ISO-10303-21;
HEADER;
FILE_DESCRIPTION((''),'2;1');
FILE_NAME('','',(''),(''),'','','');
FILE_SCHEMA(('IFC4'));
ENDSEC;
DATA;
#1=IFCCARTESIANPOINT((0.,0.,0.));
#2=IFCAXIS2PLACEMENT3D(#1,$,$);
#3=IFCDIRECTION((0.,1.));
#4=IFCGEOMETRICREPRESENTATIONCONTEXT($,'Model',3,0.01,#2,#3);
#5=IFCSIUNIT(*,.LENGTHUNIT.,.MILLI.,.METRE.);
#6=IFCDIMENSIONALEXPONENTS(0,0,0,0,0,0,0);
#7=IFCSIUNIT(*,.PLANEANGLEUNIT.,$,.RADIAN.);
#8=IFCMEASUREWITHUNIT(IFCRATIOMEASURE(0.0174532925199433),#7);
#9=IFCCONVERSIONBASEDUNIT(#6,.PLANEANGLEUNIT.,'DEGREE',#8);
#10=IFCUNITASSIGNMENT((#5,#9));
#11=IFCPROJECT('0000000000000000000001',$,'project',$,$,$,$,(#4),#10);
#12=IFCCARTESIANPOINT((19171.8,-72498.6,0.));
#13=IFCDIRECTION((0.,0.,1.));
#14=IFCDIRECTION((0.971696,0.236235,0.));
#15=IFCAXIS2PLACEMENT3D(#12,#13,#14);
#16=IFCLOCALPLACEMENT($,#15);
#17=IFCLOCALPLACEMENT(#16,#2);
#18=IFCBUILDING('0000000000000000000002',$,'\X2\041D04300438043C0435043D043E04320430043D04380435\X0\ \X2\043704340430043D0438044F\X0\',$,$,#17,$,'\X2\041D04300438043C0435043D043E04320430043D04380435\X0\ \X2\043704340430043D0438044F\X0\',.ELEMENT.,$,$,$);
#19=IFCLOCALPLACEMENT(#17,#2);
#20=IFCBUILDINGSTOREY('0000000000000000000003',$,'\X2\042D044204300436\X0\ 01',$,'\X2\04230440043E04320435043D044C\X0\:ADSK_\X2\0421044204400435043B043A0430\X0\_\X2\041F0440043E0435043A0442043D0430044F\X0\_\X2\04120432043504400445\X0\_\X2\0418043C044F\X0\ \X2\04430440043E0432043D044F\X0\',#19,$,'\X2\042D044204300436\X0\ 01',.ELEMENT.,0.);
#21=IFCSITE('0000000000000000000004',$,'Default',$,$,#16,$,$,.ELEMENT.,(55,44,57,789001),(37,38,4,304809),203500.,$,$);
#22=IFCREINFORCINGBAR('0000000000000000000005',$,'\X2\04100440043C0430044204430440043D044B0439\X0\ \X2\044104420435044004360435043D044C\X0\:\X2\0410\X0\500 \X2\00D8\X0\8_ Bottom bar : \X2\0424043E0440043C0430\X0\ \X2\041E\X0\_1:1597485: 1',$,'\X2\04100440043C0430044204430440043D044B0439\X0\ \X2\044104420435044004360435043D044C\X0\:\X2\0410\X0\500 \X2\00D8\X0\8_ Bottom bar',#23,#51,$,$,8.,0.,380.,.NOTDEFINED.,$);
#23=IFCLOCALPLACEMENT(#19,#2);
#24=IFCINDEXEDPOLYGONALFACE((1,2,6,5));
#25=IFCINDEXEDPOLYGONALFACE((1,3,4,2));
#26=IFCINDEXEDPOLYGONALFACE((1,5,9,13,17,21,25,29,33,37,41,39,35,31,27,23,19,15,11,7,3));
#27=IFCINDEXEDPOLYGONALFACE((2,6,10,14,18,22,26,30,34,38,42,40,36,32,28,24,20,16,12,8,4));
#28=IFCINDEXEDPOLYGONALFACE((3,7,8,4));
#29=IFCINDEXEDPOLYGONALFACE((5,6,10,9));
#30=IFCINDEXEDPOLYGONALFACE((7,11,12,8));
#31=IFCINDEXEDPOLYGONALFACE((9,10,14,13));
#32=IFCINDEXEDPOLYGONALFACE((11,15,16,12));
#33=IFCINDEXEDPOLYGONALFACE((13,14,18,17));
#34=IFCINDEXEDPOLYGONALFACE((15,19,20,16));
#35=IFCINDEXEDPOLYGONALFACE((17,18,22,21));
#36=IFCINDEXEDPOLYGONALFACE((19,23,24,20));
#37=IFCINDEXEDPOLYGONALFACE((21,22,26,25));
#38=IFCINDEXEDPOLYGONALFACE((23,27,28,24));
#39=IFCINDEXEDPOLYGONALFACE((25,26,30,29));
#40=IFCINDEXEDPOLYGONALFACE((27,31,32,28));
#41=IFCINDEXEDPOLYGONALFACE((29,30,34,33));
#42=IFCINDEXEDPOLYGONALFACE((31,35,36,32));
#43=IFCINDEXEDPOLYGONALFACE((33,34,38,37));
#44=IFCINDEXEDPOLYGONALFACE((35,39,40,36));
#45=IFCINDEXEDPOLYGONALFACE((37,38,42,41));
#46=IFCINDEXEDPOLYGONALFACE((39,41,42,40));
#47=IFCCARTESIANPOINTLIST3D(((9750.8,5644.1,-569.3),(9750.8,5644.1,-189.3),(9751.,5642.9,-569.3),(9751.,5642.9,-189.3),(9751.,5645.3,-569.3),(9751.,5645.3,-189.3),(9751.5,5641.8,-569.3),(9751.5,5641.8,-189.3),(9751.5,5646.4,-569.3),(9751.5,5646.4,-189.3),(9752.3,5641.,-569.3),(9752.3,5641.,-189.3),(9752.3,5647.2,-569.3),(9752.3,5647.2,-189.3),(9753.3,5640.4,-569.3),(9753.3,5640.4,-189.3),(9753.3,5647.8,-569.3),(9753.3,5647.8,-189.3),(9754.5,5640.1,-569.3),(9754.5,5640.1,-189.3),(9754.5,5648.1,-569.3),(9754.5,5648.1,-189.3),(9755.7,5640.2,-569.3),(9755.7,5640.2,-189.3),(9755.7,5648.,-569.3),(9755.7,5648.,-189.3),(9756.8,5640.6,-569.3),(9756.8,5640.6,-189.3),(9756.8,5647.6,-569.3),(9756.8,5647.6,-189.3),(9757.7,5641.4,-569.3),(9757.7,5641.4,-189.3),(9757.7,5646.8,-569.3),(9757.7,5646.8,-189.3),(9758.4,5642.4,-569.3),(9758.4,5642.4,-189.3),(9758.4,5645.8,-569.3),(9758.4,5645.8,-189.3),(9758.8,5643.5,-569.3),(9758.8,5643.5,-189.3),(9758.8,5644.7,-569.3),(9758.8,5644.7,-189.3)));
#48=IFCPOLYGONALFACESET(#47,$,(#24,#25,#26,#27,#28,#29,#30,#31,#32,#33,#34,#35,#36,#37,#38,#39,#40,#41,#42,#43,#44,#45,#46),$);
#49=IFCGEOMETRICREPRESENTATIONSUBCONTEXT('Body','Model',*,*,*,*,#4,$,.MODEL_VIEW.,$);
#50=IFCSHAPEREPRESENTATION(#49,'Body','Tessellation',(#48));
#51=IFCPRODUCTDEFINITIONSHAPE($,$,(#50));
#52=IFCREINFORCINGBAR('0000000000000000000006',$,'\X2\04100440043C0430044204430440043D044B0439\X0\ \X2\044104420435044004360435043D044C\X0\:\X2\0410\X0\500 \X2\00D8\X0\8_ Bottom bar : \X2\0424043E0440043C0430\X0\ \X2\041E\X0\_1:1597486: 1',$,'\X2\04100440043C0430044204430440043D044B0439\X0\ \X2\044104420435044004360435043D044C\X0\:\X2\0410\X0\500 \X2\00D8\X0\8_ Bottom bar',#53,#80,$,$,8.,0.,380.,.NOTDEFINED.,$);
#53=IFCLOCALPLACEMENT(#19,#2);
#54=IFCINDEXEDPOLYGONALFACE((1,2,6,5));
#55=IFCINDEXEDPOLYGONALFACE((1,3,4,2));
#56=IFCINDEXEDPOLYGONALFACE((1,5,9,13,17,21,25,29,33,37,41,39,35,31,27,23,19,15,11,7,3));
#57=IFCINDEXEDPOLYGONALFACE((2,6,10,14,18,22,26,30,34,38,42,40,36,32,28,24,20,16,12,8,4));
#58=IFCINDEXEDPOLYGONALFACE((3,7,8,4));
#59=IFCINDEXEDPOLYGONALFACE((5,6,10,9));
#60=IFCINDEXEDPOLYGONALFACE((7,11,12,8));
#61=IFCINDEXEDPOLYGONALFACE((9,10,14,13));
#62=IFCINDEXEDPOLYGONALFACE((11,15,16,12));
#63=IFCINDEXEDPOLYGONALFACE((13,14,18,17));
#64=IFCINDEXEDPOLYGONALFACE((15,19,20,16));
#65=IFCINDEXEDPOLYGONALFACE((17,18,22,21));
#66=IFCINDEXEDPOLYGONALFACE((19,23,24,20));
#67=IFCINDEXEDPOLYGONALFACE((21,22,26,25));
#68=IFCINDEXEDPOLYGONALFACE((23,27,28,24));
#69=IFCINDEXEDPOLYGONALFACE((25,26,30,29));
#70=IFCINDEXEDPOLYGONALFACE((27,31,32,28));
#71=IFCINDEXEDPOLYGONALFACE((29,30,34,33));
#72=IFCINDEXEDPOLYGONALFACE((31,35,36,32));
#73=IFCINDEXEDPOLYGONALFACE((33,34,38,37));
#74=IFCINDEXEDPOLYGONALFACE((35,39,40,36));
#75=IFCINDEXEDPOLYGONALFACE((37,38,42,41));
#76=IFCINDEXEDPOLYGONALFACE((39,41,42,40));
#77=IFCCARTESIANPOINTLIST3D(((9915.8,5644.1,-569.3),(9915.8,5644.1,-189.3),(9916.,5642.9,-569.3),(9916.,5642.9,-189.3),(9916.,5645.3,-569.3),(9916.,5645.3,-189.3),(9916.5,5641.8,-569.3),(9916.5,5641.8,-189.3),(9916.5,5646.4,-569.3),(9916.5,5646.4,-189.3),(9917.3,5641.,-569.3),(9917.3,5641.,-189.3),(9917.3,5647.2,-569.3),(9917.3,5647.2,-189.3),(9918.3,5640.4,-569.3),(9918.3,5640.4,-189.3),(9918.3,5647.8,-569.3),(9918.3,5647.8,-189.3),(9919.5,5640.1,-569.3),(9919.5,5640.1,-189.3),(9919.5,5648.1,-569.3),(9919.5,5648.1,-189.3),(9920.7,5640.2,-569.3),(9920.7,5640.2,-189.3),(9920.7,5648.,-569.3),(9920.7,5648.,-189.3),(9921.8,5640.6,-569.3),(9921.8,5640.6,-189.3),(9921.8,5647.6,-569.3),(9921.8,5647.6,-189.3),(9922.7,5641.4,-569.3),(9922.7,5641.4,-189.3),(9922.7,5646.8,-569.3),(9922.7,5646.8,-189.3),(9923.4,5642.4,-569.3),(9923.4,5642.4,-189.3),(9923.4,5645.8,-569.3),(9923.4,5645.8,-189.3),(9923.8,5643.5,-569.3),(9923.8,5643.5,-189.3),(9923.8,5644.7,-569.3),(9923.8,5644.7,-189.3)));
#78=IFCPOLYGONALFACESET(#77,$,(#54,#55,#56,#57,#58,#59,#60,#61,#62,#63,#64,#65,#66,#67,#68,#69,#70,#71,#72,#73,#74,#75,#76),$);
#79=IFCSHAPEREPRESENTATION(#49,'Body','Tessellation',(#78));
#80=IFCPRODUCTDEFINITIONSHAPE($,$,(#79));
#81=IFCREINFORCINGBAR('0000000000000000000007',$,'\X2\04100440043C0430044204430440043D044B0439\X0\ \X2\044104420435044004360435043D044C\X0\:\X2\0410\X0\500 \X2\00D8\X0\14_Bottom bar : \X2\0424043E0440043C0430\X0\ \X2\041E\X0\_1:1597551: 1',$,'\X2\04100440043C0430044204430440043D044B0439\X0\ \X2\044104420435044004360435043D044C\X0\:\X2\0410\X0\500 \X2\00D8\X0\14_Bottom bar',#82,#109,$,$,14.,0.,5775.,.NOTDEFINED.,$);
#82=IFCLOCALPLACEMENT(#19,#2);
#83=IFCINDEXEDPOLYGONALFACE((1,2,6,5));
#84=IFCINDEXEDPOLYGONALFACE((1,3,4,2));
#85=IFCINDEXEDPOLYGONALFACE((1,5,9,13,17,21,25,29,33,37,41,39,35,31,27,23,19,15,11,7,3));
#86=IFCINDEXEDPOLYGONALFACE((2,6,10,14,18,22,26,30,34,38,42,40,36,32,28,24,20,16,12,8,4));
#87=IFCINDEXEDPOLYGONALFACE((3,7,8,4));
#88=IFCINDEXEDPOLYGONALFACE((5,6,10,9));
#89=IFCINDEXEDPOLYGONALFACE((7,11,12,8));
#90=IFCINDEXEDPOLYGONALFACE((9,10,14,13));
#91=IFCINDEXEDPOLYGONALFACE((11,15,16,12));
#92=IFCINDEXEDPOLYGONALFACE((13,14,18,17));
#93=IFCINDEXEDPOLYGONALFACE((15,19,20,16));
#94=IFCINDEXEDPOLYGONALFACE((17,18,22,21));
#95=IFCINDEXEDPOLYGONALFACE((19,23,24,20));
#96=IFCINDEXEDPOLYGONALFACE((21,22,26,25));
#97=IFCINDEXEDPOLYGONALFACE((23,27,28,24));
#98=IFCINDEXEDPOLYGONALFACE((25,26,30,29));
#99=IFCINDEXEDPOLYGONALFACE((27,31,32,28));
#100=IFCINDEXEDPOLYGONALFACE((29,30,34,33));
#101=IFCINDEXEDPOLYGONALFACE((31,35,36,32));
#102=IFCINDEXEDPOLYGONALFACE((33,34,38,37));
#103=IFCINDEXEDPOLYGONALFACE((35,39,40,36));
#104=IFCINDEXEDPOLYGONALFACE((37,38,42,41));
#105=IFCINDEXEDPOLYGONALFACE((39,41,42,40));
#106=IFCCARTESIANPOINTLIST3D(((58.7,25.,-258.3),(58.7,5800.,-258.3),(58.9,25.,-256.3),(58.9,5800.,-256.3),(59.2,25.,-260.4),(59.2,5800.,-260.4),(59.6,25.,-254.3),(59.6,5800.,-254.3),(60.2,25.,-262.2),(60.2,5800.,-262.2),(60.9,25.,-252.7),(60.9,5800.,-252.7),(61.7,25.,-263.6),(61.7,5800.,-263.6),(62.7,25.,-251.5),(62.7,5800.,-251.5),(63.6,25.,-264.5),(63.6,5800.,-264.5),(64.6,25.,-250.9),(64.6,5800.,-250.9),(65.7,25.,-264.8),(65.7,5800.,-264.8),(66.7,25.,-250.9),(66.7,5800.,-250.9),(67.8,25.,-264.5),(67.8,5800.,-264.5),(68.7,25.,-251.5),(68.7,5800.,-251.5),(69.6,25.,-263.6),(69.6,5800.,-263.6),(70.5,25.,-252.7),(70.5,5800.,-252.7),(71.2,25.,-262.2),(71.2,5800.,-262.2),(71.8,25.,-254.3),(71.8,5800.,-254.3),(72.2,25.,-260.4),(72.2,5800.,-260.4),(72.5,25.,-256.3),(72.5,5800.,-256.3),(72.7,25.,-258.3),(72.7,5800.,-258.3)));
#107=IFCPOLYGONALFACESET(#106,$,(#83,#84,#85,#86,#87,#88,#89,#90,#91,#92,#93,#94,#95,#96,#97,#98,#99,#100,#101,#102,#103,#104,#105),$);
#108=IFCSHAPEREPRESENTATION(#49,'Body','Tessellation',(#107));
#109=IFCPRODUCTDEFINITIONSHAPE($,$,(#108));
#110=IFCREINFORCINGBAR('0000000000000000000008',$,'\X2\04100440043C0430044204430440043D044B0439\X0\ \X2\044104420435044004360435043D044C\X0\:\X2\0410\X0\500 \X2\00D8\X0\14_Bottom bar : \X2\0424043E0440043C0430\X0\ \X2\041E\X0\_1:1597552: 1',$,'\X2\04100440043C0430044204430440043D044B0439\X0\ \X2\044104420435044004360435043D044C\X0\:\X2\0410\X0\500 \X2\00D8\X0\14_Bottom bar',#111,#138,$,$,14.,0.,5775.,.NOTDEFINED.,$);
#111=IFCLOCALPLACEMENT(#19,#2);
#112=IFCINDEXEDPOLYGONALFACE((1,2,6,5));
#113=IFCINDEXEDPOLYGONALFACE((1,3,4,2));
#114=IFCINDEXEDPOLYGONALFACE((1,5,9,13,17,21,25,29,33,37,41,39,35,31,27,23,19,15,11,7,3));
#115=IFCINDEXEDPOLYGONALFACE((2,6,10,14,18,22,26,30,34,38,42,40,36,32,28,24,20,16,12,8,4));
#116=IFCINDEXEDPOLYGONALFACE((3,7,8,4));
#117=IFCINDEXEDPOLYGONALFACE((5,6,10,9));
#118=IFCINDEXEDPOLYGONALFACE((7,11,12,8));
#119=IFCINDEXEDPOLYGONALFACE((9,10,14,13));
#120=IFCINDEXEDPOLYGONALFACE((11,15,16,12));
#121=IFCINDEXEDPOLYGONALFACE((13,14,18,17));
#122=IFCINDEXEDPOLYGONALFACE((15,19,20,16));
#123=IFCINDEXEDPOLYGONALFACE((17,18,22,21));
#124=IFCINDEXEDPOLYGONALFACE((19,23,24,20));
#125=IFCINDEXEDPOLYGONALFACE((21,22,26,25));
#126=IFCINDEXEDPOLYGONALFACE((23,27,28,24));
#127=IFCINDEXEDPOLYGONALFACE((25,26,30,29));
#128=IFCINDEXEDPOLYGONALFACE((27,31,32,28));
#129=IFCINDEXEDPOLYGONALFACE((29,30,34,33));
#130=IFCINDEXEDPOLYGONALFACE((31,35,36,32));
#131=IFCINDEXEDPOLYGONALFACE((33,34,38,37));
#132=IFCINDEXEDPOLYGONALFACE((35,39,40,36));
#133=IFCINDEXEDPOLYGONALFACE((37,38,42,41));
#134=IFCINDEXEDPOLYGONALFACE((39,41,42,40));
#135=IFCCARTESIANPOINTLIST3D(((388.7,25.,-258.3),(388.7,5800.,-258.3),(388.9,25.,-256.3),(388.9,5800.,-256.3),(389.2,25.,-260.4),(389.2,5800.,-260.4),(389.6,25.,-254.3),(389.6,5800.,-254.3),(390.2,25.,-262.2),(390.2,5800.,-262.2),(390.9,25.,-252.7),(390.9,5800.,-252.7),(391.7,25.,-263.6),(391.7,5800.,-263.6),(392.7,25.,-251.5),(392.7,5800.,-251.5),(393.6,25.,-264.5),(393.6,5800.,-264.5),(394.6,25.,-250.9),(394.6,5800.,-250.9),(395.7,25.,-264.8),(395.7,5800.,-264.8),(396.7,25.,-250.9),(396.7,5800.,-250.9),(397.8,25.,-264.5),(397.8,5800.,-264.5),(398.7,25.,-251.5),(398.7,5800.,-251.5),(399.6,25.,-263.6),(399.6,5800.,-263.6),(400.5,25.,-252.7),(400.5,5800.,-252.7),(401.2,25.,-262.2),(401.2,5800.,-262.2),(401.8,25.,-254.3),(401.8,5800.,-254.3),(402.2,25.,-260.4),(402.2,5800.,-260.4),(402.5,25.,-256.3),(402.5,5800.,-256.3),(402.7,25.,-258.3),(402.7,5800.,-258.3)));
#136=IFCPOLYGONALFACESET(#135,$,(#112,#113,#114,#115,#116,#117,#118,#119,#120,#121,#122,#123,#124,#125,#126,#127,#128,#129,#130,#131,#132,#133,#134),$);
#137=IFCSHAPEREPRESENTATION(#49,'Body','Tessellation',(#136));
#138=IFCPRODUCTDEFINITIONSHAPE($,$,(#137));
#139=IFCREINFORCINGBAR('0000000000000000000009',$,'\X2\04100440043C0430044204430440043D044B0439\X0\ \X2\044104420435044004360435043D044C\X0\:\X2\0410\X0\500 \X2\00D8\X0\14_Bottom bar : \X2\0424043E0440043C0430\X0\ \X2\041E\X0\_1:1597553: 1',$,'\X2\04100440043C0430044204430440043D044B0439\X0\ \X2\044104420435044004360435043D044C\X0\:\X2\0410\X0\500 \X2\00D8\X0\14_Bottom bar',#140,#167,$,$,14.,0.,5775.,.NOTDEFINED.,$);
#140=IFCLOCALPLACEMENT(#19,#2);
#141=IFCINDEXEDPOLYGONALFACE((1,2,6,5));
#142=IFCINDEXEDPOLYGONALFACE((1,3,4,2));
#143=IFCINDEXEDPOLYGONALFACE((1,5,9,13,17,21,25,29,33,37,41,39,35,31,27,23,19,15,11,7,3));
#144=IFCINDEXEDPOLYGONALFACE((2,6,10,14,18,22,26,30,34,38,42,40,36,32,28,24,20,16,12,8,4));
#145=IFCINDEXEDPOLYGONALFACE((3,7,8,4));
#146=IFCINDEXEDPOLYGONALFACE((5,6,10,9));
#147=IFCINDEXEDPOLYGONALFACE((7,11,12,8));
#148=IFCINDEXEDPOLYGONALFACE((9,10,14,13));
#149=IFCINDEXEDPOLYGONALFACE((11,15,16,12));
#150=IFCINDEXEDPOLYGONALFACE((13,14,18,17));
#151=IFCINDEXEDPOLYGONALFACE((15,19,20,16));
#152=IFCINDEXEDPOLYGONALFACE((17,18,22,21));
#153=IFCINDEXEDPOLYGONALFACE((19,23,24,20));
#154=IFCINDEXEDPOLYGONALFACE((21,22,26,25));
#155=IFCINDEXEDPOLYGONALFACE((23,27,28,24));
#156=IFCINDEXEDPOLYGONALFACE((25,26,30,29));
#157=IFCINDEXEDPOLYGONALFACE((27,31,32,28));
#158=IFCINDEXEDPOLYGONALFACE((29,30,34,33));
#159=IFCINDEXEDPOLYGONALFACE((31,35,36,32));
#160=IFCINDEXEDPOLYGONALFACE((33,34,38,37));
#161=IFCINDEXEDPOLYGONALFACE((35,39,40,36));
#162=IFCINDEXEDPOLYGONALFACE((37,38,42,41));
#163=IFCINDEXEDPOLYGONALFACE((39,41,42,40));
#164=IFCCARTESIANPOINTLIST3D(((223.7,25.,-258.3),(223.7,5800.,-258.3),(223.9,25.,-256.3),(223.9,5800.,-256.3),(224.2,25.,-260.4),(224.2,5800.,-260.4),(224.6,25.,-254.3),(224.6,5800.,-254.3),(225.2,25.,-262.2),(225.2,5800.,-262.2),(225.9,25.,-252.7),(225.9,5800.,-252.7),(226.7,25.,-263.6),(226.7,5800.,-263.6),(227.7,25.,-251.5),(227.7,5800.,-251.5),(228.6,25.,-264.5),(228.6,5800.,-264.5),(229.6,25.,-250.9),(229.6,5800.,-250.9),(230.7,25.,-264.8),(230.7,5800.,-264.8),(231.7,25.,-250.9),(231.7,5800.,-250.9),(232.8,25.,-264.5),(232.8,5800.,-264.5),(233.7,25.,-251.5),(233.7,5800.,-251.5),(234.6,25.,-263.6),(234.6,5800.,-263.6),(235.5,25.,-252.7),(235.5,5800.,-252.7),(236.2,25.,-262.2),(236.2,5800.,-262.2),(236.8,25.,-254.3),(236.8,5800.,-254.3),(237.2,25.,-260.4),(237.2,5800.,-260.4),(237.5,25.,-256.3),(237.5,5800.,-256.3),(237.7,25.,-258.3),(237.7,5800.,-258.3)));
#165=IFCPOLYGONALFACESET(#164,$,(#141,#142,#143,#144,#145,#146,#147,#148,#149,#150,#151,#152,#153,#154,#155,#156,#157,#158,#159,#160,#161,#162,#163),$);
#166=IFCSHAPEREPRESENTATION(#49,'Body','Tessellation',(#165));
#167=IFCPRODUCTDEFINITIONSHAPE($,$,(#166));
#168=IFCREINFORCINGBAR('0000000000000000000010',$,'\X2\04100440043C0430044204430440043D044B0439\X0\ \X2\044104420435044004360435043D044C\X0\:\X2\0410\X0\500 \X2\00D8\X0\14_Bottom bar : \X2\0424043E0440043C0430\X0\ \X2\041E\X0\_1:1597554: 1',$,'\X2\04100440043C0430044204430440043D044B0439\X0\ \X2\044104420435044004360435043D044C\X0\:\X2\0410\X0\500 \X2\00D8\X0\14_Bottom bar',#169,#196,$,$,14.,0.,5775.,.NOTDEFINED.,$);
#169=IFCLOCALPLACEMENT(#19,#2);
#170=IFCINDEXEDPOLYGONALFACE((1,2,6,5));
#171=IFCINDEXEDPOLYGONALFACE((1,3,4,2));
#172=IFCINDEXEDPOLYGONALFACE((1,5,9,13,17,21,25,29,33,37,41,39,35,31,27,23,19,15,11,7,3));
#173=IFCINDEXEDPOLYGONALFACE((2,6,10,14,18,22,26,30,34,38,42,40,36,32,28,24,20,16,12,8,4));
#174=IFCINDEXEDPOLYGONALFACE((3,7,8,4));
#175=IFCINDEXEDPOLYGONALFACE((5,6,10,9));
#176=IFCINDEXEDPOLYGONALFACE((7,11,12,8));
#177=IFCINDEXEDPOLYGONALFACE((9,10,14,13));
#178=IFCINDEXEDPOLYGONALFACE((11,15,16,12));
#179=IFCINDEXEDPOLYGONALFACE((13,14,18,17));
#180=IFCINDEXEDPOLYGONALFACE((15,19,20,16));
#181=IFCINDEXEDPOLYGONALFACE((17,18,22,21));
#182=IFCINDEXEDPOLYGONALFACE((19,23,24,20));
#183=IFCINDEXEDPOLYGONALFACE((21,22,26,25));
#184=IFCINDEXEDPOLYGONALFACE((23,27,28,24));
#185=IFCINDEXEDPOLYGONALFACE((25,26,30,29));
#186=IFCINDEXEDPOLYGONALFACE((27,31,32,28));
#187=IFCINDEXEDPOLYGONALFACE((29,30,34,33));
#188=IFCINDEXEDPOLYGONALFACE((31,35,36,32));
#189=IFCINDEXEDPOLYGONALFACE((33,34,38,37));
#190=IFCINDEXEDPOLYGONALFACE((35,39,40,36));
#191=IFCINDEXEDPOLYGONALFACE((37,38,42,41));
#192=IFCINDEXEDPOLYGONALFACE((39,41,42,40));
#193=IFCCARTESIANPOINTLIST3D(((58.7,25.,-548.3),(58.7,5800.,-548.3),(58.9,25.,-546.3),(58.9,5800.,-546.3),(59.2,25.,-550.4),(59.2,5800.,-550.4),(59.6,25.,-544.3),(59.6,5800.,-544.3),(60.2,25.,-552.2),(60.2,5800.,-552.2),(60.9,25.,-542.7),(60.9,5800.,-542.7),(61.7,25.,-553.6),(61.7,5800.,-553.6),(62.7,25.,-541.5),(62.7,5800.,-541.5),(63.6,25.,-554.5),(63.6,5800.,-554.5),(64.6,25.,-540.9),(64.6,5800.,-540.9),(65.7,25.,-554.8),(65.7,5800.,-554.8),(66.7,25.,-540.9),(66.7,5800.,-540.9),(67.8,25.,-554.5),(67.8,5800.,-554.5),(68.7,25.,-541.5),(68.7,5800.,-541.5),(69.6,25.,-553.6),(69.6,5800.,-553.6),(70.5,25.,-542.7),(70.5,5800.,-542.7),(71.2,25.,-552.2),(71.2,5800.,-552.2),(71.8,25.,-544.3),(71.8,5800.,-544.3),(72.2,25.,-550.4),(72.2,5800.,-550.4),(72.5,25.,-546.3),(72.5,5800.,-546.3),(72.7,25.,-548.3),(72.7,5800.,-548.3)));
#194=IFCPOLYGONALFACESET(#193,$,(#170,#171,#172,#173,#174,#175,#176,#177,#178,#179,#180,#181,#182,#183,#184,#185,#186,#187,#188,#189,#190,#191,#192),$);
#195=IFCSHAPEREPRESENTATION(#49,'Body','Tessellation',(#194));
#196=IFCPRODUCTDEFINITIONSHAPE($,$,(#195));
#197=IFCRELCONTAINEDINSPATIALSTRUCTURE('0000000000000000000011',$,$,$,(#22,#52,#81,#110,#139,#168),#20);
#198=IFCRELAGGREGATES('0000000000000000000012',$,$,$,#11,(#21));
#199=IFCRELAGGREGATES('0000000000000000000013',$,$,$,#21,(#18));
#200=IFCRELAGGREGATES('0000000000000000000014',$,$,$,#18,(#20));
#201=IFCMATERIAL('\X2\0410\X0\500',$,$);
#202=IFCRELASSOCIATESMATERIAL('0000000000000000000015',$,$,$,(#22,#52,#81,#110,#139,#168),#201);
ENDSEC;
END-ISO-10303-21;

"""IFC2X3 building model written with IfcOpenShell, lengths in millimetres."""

from ifc_helpers import new_model, entity, si_unit, converted_unit, direction, frame, origin, place, context, subcontext, project, spatial, material, element, save


model = new_model("IFC2X3")

# Units and contexts
model_context = context("Model", 3, precision=0.01, world=origin(), true_north=direction((0.0, 1.0)))
body_context = subcontext(model_context, "Body", "Model", "MODEL_VIEW")
ifc_project = project(units=[si_unit("LENGTHUNIT", "METRE", prefix="MILLI"), converted_unit("PLANEANGLEUNIT", "DEGREE", entity("IfcRatioMeasure", 0.0174532925199433), si_unit("PLANEANGLEUNIT", "RADIAN"), dimensions=[0, 0, 0, 0, 0, 0, 0])], contexts=[model_context])

# Site, building, storey
site_placement = place(None, frame((19171.8, -72498.6, 0.0), z_axis=(0.0, 0.0, 1.0), x_axis=(0.971696, 0.236235, 0.0)))
site = spatial("IfcSite", under=ifc_project, at=site_placement, Name="Default", CompositionType="ELEMENT", RefLatitude=(55, 44, 57, 789001), RefLongitude=(37, 38, 4, 304809), RefElevation=203500.0)
building_placement = place(site_placement, origin())
building = spatial("IfcBuilding", under=site, at=building_placement, Name="Наименование здания", LongName="Наименование здания", CompositionType="ELEMENT")
storey_placement = place(building_placement, origin())
storey = spatial("IfcBuildingStorey", under=building, at=storey_placement, Name="Этаж 01", ObjectType="Уровень:ADSK_Стрелка_Проектная_Вверх_Имя уровня", LongName="Этаж 01", CompositionType="ELEMENT", Elevation=0.0)

# Reinforcing bars
ifc_material = material(Name="А500")
placement = place(storey_placement, origin())
element("IfcReinforcingBar", 1, at=placement, inside=storey, material=ifc_material, Name="Арматурный стержень:А500 Ø8_ Bottom bar : Форма О_1:1597485: 1", ObjectType="Арматурный стержень:А500 Ø8_ Bottom bar", BarLength=380.0, BarRole="NOTDEFINED", CrossSectionArea=0.0, NominalDiameter=8.0, context=body_context, shape_type="AdvancedSweptSolid", body=[
    entity("IfcSweptDiskSolid", entity("IfcCompositeCurve", [entity("IfcCompositeCurveSegment", "CONTINUOUS", True, entity("IfcPolyline", [entity("IfcCartesianPoint", [9754.8, 5644.1, -189.3]), entity("IfcCartesianPoint", [9754.8, 5644.1, -569.3])]))], False), 4.0, None, 0.0, 1.0),
])
element("IfcReinforcingBar", 2, at=placement, inside=storey, material=ifc_material, Name="Арматурный стержень:А500 Ø8_ Bottom bar : Форма О_1:1597486: 1", ObjectType="Арматурный стержень:А500 Ø8_ Bottom bar", BarLength=380.0, BarRole="NOTDEFINED", CrossSectionArea=0.0, NominalDiameter=8.0, context=body_context, shape_type="AdvancedSweptSolid", body=[
    entity("IfcSweptDiskSolid", entity("IfcCompositeCurve", [entity("IfcCompositeCurveSegment", "CONTINUOUS", True, entity("IfcPolyline", [entity("IfcCartesianPoint", [9919.8, 5644.1, -189.3]), entity("IfcCartesianPoint", [9919.8, 5644.1, -569.3])]))], False), 4.0, None, 0.0, 1.0),
])
element("IfcReinforcingBar", 3, at=placement, inside=storey, material=ifc_material, Name="Арматурный стержень:А500 Ø14_Bottom bar : Форма О_1:1597551: 1", ObjectType="Арматурный стержень:А500 Ø14_Bottom bar", BarLength=5775.0, BarRole="NOTDEFINED", CrossSectionArea=0.0, NominalDiameter=14.0, context=body_context, shape_type="AdvancedSweptSolid", body=[
    entity("IfcSweptDiskSolid", entity("IfcCompositeCurve", [entity("IfcCompositeCurveSegment", "CONTINUOUS", True, entity("IfcPolyline", [entity("IfcCartesianPoint", [65.7, 5800.0, -257.8]), entity("IfcCartesianPoint", [65.7, 25.0, -257.8])]))], False), 7.0, None, 0.0, 1.0),
])
element("IfcReinforcingBar", 4, at=placement, inside=storey, material=ifc_material, Name="Арматурный стержень:А500 Ø14_Bottom bar : Форма О_1:1597552: 1", ObjectType="Арматурный стержень:А500 Ø14_Bottom bar", BarLength=5775.0, BarRole="NOTDEFINED", CrossSectionArea=0.0, NominalDiameter=14.0, context=body_context, shape_type="AdvancedSweptSolid", body=[
    entity("IfcSweptDiskSolid", entity("IfcCompositeCurve", [entity("IfcCompositeCurveSegment", "CONTINUOUS", True, entity("IfcPolyline", [entity("IfcCartesianPoint", [395.7, 5800.0, -257.8]), entity("IfcCartesianPoint", [395.7, 25.0, -257.8])]))], False), 7.0, None, 0.0, 1.0),
])
element("IfcReinforcingBar", 5, at=placement, inside=storey, material=ifc_material, Name="Арматурный стержень:А500 Ø14_Bottom bar : Форма О_1:1597553: 1", ObjectType="Арматурный стержень:А500 Ø14_Bottom bar", BarLength=5775.0, BarRole="NOTDEFINED", CrossSectionArea=0.0, NominalDiameter=14.0, context=body_context, shape_type="AdvancedSweptSolid", body=[
    entity("IfcSweptDiskSolid", entity("IfcCompositeCurve", [entity("IfcCompositeCurveSegment", "CONTINUOUS", True, entity("IfcPolyline", [entity("IfcCartesianPoint", [230.7, 5800.0, -257.8]), entity("IfcCartesianPoint", [230.7, 25.0, -257.8])]))], False), 7.0, None, 0.0, 1.0),
])
element("IfcReinforcingBar", 6, at=placement, inside=storey, material=ifc_material, Name="Арматурный стержень:А500 Ø14_Bottom bar : Форма О_1:1597554: 1", ObjectType="Арматурный стержень:А500 Ø14_Bottom bar", BarLength=5775.0, BarRole="NOTDEFINED", CrossSectionArea=0.0, NominalDiameter=14.0, context=body_context, shape_type="AdvancedSweptSolid", body=[
    entity("IfcSweptDiskSolid", entity("IfcCompositeCurve", [entity("IfcCompositeCurveSegment", "CONTINUOUS", True, entity("IfcPolyline", [entity("IfcCartesianPoint", [65.7, 5800.0, -547.8]), entity("IfcCartesianPoint", [65.7, 25.0, -547.8])]))], False), 7.0, None, 0.0, 1.0),
])

save(model, "model.ifc")
